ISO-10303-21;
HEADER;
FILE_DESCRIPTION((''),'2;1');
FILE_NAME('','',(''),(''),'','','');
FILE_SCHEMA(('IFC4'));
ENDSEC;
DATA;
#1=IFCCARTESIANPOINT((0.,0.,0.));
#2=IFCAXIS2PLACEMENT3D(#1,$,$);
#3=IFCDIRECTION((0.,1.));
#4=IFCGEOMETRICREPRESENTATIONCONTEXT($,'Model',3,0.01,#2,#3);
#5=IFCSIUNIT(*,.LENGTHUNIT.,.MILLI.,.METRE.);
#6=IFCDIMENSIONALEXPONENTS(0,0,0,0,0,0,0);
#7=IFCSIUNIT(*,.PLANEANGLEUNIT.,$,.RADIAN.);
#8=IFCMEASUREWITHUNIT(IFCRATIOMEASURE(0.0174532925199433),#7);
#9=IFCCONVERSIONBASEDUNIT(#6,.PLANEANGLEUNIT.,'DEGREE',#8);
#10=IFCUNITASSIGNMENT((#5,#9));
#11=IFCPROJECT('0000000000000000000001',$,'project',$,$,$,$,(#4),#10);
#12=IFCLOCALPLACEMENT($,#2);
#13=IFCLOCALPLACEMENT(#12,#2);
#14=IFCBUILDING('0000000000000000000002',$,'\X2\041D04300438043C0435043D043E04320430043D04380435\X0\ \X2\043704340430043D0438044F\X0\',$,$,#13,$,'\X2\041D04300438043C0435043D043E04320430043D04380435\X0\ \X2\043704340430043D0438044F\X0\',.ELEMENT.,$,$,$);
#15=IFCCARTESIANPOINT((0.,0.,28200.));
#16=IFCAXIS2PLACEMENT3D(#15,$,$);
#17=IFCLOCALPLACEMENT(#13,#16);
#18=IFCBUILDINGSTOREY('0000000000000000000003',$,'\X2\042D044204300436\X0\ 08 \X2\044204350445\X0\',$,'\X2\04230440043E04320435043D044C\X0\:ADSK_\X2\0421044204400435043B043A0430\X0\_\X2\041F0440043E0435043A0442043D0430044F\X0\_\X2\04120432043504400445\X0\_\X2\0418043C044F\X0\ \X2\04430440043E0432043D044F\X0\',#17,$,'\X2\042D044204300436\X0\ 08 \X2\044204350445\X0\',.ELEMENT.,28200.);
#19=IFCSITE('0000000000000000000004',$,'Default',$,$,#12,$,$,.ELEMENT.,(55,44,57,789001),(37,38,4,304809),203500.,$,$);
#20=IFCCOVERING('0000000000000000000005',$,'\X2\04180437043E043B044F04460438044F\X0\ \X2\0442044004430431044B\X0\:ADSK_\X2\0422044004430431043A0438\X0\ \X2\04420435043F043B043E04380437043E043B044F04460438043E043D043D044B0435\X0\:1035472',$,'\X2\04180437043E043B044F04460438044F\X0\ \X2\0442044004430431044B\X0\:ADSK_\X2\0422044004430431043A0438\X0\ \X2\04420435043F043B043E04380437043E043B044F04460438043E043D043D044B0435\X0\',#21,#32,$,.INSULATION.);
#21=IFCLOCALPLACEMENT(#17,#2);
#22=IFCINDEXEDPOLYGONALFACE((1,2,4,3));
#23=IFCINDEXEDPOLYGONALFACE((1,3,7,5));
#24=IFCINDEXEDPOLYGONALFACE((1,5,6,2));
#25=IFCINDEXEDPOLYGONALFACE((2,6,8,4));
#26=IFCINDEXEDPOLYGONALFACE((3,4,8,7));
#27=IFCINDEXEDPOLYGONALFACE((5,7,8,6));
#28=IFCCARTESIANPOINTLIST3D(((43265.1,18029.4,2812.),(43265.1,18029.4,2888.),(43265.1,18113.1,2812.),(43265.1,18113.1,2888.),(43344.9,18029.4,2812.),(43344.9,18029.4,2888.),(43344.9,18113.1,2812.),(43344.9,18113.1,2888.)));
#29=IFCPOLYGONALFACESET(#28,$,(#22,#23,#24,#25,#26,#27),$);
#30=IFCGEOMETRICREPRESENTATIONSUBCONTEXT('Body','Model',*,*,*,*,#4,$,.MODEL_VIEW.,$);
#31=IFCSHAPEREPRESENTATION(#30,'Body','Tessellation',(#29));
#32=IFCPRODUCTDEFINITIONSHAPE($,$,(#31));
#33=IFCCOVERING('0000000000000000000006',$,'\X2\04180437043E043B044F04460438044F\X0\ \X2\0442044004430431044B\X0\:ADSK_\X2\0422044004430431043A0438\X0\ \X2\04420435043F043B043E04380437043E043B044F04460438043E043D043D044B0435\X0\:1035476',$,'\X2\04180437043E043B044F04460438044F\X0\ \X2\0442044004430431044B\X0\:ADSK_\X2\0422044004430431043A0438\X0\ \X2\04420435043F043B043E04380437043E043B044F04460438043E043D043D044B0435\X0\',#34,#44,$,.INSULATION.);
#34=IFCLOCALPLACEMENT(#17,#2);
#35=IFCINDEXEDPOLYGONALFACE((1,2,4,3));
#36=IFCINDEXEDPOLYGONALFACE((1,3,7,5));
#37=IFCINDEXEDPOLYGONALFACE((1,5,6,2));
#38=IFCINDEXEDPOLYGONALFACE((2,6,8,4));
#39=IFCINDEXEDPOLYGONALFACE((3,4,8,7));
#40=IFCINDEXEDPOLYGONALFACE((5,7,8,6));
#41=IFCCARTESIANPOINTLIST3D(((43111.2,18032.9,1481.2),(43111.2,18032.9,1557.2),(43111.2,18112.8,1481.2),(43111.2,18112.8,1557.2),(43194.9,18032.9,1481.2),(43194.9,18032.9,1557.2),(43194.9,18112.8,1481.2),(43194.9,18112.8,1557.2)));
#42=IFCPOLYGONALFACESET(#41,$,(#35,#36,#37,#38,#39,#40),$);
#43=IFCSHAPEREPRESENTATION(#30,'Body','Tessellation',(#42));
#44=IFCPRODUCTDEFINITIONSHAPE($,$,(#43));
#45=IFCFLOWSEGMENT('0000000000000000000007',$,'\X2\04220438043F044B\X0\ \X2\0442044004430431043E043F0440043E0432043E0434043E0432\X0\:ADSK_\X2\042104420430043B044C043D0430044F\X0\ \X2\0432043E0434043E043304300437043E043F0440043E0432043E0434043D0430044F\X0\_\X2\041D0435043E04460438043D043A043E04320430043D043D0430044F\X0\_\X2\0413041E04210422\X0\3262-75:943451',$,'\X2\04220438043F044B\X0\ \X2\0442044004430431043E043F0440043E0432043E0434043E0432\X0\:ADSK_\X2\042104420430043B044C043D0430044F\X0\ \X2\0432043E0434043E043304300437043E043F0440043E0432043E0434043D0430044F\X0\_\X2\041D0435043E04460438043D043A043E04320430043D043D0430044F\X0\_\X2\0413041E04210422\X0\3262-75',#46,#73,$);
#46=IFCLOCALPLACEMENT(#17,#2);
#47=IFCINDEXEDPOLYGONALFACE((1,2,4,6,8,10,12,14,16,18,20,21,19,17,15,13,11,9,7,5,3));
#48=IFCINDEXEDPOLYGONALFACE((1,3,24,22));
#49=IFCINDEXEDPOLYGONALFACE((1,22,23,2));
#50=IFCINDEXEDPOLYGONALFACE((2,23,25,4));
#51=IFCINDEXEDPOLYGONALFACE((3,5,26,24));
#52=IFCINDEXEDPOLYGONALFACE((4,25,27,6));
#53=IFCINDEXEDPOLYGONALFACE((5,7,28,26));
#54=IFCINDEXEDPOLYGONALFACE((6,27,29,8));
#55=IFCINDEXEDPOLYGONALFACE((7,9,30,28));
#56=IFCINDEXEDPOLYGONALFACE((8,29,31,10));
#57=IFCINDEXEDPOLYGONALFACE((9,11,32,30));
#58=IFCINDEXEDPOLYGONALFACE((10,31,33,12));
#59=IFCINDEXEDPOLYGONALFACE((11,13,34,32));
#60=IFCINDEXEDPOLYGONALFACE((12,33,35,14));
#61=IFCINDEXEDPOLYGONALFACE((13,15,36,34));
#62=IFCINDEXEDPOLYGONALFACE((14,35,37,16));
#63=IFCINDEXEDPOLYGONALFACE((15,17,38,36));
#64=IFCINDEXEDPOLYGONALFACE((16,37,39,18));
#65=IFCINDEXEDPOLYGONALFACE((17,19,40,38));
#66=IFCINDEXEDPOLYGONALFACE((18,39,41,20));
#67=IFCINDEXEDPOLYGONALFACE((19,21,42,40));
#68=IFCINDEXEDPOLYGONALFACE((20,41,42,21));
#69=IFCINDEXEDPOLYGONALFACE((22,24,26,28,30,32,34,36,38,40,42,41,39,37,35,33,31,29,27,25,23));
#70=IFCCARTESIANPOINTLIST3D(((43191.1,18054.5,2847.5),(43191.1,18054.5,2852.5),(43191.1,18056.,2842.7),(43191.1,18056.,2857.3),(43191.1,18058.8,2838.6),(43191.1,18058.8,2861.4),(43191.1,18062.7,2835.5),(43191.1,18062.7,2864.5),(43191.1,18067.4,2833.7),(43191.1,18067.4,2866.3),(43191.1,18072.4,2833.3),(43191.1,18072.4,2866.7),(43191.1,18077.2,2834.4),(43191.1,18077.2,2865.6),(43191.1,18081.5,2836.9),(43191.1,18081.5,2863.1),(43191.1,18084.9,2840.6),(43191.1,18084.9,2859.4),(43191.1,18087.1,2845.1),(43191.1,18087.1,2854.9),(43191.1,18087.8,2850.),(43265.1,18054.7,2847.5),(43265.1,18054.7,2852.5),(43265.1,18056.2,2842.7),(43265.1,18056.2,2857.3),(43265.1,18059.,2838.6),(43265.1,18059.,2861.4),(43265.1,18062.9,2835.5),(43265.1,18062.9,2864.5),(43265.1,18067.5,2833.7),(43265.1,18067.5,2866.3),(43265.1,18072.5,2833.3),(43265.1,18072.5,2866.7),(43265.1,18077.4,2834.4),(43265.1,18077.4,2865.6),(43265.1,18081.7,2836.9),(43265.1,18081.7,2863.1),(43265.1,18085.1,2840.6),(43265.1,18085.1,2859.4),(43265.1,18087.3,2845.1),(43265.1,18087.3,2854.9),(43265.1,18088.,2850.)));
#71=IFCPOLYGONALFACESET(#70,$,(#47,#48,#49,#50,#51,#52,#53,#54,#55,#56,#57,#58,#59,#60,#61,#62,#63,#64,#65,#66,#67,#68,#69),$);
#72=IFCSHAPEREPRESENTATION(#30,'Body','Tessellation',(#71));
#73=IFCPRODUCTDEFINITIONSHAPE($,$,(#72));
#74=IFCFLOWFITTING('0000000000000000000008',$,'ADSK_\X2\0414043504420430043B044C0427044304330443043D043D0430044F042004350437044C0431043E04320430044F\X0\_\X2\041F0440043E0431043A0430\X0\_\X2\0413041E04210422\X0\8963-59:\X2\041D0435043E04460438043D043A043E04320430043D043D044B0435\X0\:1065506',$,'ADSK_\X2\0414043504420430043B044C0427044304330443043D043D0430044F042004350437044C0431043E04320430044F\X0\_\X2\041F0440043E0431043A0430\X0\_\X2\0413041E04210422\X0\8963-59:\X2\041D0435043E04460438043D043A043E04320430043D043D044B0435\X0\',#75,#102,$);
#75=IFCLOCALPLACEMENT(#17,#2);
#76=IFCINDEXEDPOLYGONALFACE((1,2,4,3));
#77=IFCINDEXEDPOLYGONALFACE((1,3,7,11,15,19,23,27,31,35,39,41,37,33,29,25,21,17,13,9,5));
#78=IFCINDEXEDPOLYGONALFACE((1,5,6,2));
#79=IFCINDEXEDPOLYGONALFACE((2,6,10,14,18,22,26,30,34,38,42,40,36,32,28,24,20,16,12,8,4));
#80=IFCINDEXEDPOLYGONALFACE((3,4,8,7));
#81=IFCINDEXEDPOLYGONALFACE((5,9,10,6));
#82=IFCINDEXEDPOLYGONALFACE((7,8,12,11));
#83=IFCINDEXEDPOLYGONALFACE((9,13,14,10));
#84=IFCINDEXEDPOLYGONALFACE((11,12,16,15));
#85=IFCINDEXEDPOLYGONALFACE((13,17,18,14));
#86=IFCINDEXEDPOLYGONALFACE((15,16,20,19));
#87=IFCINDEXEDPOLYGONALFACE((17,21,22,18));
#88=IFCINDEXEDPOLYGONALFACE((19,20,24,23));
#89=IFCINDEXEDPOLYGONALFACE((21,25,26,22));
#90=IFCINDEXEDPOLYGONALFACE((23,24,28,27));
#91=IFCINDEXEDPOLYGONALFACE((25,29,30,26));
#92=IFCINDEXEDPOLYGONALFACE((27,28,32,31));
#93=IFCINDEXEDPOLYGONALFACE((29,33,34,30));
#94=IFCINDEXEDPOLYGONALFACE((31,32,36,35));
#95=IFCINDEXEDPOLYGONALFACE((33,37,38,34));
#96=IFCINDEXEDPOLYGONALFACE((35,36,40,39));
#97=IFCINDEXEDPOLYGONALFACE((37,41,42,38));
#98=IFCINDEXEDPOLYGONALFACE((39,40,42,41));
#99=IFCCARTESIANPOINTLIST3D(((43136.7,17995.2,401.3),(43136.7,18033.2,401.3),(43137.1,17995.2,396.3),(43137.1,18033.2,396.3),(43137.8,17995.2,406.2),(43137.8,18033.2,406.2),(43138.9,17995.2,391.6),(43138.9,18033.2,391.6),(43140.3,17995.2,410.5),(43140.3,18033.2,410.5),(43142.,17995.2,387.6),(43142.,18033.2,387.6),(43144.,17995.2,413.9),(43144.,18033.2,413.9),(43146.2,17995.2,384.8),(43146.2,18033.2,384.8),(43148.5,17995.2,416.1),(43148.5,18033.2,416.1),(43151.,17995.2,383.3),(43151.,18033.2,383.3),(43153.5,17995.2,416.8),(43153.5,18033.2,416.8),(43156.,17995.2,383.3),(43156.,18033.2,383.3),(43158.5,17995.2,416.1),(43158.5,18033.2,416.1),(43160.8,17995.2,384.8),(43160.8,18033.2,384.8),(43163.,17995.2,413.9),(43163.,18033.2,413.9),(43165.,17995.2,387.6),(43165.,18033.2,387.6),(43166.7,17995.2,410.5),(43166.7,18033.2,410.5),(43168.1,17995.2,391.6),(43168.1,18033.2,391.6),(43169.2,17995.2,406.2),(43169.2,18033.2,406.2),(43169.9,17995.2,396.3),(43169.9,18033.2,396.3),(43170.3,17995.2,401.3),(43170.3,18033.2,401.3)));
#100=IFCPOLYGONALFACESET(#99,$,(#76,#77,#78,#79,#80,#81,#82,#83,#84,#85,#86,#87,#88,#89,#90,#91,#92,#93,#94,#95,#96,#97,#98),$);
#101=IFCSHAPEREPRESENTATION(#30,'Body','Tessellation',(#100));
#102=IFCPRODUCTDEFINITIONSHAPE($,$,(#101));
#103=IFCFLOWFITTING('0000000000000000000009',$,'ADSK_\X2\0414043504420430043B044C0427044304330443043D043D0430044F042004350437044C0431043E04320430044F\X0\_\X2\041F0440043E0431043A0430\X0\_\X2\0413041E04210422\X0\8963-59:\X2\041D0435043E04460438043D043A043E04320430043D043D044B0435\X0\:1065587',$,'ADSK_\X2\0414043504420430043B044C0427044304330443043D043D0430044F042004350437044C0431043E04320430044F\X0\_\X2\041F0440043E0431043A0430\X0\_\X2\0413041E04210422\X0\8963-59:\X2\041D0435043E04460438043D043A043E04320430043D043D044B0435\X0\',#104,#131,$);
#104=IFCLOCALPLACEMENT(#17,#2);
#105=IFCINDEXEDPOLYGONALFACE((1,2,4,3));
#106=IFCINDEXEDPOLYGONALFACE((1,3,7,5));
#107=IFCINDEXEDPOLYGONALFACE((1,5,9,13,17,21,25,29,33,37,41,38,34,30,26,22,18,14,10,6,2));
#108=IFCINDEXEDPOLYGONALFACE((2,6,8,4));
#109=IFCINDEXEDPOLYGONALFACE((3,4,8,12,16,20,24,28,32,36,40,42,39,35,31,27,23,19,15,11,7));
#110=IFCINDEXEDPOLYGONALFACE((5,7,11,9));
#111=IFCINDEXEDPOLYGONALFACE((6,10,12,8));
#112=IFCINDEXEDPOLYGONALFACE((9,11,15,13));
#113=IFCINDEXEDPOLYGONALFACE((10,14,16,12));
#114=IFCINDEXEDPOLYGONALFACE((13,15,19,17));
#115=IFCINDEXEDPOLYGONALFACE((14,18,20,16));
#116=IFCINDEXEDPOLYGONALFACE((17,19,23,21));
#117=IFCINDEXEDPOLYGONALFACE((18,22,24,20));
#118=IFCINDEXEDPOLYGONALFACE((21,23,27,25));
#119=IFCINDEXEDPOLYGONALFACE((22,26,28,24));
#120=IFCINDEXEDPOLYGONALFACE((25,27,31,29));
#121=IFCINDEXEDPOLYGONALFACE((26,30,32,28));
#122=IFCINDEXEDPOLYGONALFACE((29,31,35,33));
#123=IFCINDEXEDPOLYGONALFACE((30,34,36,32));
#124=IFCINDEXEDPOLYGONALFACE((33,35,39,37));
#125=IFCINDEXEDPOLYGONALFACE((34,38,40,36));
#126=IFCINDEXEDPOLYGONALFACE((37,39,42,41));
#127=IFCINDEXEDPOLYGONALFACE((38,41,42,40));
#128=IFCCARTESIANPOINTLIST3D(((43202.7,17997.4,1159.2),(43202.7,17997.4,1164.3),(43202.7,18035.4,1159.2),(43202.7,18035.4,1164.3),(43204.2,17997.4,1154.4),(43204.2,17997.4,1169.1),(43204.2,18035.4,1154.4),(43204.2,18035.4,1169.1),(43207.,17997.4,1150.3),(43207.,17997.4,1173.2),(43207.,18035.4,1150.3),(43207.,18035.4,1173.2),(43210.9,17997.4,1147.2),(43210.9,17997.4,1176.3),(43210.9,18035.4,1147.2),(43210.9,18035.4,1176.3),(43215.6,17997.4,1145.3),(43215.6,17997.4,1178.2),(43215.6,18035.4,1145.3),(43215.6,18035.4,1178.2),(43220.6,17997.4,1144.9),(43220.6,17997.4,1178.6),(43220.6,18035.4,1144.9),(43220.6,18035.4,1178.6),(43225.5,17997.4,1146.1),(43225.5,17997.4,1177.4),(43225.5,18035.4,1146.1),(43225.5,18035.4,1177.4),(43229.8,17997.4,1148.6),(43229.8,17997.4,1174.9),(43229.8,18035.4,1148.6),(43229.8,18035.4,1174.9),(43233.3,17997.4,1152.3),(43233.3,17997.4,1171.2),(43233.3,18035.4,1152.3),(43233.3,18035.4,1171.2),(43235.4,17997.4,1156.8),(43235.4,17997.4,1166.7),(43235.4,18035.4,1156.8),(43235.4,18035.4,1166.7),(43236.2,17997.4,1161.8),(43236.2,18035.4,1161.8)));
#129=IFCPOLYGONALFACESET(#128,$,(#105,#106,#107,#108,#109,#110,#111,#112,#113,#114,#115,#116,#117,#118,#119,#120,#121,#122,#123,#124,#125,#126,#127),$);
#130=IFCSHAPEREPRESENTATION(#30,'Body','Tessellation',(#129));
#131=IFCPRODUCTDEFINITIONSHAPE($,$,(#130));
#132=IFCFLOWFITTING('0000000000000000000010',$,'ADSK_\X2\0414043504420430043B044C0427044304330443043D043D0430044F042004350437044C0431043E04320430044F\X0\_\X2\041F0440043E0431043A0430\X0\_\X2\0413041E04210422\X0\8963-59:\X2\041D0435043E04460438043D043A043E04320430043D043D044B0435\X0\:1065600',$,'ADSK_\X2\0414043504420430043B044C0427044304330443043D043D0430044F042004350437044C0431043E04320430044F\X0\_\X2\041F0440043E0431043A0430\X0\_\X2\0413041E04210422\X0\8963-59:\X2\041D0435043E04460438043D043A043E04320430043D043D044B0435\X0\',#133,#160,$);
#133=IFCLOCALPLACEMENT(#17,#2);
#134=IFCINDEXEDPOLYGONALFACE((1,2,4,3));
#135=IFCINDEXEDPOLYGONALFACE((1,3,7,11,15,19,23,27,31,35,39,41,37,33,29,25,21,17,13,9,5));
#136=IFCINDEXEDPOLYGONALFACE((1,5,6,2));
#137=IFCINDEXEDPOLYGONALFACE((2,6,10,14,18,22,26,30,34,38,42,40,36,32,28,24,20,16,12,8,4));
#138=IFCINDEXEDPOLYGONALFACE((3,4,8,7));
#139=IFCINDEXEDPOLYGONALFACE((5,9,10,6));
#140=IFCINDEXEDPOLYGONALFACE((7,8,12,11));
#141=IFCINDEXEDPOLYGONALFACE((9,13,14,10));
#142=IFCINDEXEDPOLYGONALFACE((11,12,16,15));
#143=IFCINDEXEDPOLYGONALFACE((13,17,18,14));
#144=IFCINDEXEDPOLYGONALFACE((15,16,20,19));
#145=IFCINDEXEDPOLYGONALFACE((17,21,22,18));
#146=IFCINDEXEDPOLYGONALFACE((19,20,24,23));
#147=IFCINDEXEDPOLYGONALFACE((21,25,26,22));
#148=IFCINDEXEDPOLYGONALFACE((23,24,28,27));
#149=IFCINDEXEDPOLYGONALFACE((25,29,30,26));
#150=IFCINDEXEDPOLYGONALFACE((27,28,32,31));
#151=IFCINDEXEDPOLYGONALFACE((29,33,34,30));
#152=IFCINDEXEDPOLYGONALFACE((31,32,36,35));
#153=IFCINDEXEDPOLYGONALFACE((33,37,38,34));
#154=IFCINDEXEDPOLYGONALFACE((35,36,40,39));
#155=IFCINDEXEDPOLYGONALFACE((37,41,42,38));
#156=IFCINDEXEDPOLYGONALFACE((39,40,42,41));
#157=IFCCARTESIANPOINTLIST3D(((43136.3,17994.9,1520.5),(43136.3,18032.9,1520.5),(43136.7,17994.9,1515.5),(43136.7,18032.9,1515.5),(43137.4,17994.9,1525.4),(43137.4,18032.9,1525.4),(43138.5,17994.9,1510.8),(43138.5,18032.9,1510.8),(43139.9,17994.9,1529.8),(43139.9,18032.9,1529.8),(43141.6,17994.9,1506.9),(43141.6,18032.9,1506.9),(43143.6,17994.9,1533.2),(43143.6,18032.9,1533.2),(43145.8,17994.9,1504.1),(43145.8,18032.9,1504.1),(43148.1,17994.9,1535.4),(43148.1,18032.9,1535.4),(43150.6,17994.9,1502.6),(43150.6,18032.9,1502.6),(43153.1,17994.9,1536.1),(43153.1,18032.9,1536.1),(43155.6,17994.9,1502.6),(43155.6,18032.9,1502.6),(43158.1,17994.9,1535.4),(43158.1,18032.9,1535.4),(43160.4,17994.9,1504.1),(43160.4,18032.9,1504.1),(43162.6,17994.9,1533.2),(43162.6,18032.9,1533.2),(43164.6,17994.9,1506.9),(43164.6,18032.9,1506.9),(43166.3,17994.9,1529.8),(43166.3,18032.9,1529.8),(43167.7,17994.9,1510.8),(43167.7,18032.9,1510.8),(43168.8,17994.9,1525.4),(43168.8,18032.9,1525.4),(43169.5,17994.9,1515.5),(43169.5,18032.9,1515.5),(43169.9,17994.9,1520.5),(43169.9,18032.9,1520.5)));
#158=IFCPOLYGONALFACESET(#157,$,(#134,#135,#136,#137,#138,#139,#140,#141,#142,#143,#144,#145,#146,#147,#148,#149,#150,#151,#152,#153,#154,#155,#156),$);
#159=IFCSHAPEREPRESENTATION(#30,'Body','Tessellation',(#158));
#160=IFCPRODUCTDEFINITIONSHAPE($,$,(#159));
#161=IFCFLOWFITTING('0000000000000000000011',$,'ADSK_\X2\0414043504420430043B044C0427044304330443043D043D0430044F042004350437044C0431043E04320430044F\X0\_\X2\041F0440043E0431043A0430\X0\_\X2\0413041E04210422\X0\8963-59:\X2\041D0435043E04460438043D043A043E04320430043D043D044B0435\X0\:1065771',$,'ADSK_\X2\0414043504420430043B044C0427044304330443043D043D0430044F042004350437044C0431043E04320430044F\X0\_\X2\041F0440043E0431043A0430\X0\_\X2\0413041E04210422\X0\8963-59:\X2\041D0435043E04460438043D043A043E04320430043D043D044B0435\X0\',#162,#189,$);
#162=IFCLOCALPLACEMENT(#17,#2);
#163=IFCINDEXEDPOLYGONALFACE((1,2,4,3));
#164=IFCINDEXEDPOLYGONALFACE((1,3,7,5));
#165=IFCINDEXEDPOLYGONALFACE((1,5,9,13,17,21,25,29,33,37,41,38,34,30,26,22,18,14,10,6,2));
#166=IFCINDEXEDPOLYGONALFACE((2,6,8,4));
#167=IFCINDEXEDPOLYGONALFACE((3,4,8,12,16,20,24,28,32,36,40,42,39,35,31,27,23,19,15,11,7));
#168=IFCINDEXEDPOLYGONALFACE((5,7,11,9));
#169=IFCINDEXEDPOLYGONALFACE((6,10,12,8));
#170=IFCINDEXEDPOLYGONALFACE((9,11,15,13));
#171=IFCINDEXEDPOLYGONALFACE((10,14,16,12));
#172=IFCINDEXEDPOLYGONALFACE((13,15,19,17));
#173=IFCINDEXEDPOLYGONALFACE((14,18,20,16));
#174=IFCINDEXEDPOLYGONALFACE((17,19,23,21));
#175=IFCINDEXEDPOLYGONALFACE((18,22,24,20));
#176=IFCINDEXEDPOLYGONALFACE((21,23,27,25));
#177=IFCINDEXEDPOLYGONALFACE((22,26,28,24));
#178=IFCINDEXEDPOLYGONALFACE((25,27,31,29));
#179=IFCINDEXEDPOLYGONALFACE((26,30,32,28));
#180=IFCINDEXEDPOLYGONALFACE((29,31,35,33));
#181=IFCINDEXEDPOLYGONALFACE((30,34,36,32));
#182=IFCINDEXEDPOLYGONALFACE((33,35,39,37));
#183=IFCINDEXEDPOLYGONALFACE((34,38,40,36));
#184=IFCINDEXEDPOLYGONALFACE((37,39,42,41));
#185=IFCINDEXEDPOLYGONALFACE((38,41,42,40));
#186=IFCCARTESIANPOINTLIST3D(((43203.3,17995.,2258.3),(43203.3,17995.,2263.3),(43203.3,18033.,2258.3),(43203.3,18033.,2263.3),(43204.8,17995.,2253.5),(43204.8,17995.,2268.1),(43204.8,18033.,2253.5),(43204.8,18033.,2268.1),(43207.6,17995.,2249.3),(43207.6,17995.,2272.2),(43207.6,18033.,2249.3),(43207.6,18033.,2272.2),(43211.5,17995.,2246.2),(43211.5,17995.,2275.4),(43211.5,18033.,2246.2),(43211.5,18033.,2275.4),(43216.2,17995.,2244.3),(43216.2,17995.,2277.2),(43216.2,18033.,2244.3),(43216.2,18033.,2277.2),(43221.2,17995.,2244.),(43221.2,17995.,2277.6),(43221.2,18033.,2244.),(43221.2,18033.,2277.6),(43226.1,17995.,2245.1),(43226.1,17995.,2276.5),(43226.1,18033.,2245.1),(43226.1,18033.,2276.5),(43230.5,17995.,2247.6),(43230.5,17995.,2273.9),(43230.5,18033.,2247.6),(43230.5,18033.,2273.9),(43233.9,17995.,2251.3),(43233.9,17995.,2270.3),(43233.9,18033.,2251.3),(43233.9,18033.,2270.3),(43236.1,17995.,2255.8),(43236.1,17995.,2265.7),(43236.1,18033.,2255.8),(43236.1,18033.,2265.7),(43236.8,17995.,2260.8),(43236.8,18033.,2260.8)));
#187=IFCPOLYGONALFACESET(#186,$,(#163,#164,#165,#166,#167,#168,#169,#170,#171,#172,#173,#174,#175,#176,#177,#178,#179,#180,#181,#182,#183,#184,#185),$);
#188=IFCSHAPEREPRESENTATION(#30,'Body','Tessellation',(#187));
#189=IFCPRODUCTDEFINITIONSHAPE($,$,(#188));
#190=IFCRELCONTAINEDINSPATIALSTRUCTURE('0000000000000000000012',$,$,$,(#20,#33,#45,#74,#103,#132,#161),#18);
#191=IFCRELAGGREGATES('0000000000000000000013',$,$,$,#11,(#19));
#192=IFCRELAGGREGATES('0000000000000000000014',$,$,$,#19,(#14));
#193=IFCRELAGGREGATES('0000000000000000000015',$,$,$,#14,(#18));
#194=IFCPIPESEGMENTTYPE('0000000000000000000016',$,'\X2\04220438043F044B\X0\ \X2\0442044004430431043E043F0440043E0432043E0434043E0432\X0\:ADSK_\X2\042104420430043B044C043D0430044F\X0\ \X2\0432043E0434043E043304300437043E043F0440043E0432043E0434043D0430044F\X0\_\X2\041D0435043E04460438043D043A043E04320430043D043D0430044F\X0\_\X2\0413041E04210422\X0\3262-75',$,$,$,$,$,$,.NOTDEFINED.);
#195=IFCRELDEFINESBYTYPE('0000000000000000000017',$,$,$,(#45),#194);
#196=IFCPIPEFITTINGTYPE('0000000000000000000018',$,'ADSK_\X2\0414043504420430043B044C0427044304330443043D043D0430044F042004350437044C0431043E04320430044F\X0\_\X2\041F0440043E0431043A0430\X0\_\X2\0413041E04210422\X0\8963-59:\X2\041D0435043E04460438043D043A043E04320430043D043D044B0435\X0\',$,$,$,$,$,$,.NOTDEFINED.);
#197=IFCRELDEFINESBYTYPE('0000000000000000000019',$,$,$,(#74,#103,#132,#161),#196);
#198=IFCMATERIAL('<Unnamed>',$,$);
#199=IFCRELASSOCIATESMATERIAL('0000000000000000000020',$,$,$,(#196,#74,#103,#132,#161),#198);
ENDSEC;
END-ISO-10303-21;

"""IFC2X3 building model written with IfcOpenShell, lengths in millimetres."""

from ifc_helpers import new_model, entity, si_unit, converted_unit, direction, frame, origin, origin_2d_with_axis, place, context, subcontext, project, spatial, rectangle, circle, extrude, source, transform, mapped, material, type_object, type_shapes, element, save


model = new_model("IFC2X3")

# Units and contexts
model_context = context("Model", 3, precision=0.01, world=origin(), true_north=direction((0.0, 1.0)))
body_context = subcontext(model_context, "Body", "Model", "MODEL_VIEW")
ifc_project = project(units=[si_unit("LENGTHUNIT", "METRE", prefix="MILLI"), converted_unit("PLANEANGLEUNIT", "DEGREE", entity("IfcRatioMeasure", 0.0174532925199433), si_unit("PLANEANGLEUNIT", "RADIAN"), dimensions=[0, 0, 0, 0, 0, 0, 0])], contexts=[model_context])

# Site, building, storey
site_placement = place(None, origin())
site = spatial("IfcSite", under=ifc_project, at=site_placement, Name="Default", CompositionType="ELEMENT", RefLatitude=(55, 44, 57, 789001), RefLongitude=(37, 38, 4, 304809), RefElevation=203500.0)
building_placement = place(site_placement, origin())
building = spatial("IfcBuilding", under=site, at=building_placement, Name="Наименование здания", LongName="Наименование здания", CompositionType="ELEMENT")
storey_placement = place(building_placement, frame((0.0, 0.0, 28200.0)))
storey = spatial("IfcBuildingStorey", under=building, at=storey_placement, Name="Этаж 08 тех", ObjectType="Уровень:ADSK_Стрелка_Проектная_Вверх_Имя уровня", LongName="Этаж 08 тех", CompositionType="ELEMENT", Elevation=28200.0)

# Coverings
covering_1_placement = place(storey_placement, frame((43265.1, 18029.4, 2812.0)))
element("IfcCovering", 1, at=covering_1_placement, inside=storey, Name="Изоляция трубы:ADSK_Трубки теплоизоляционные:1035472", ObjectType="Изоляция трубы:ADSK_Трубки теплоизоляционные", PredefinedType="INSULATION", context=body_context, shape_type="SweptSolid", body=[
    extrude(rectangle(XDim=79.9, YDim=83.7, at=origin_2d_with_axis()), frame((39.9, 41.9, 0.0)), (0.0, 0.0, 1.0), 76.0),
])
covering_2_placement = place(storey_placement, frame((43111.2, 18032.9, 1481.2)))
element("IfcCovering", 2, at=covering_2_placement, inside=storey, Name="Изоляция трубы:ADSK_Трубки теплоизоляционные:1035476", ObjectType="Изоляция трубы:ADSK_Трубки теплоизоляционные", PredefinedType="INSULATION", context=body_context, shape_type="SweptSolid", body=[
    extrude(rectangle(XDim=83.7, YDim=79.9, at=origin_2d_with_axis()), frame((41.9, 39.9, 0.0)), (0.0, 0.0, 1.0), 76.0),
])

# Flow segment
pipe_segment_type = type_object("IfcPipeSegmentType", Name="Типы трубопроводов:ADSK_Стальная водогазопроводная_Неоцинкованная_ГОСТ3262-75", PredefinedType="NOTDEFINED")
flow_segment_1_placement = place(storey_placement, frame((43191.1, 18052.8, 2831.7)))
element("IfcFlowSegment", 3, at=flow_segment_1_placement, inside=storey, type_object=pipe_segment_type, Name="Типы трубопроводов:ADSK_Стальная водогазопроводная_Неоцинкованная_ГОСТ3262-75:943451", ObjectType="Типы трубопроводов:ADSK_Стальная водогазопроводная_Неоцинкованная_ГОСТ3262-75", context=body_context, shape_type="SweptSolid", body=[
    extrude(circle(Radius=16.8, at=origin_2d_with_axis()), frame((0.0, 18.4, 18.4), z_axis=(0.999998, 0.001963, 0.0), x_axis=(-0.001963, 0.999998, 0.0)), (0.0, 0.0, 1.0), 74.0),
])

# Flow fittings
ifc_material = material(Name="<Unnamed>")
pipe_fitting_type_1 = type_object("IfcPipeFittingType", Name="ADSK_ДетальЧугуннаяРезьбовая_Пробка_ГОСТ8963-59:Неоцинкованные", PredefinedType="NOTDEFINED", material=ifc_material)
shared_shape_1 = source(origin(), body_context, "Body", "SweptSolid", [
    extrude(circle(Radius=16.9, at=origin_2d_with_axis()), frame((0.0, 0.0, 0.0), z_axis=(1.0, 0.0, 0.0), x_axis=(0.0, 1.0, 0.0)), (0.0, 0.0, 1.0), 38.0),
])
type_shapes(pipe_fitting_type_1, [shared_shape_1])
for number, where, z_axis, x_axis, name in (
    (4, (43153.5, 18033.2, 400.0), (-1.0, 0.0, 0.0), (0.0, -1.0, 0.0), "ADSK_ДетальЧугуннаяРезьбовая_Пробка_ГОСТ8963-59:Неоцинкованные:1065506"),
    (5, (43219.3, 18035.4, 1161.8), (0.0, 0.0, 1.0), (0.0, -1.0, 0.0), "ADSK_ДетальЧугуннаяРезьбовая_Пробка_ГОСТ8963-59:Неоцинкованные:1065587"),
    (6, (43153.1, 18032.9, 1519.2), (-1.0, 0.0, 0.0), (0.0, -1.0, 0.0), "ADSK_ДетальЧугуннаяРезьбовая_Пробка_ГОСТ8963-59:Неоцинкованные:1065600"),
    (7, (43220.0, 18033.0, 2260.8), (0.0, 0.0, 1.0), (0.0, -1.0, 0.0), "ADSK_ДетальЧугуннаяРезьбовая_Пробка_ГОСТ8963-59:Неоцинкованные:1065771"),
):
    element("IfcFlowFitting", number, at=place(storey_placement, frame(where, z_axis=z_axis, x_axis=x_axis)), inside=storey, type_object=pipe_fitting_type_1, material=ifc_material, Name=name, ObjectType="ADSK_ДетальЧугуннаяРезьбовая_Пробка_ГОСТ8963-59:Неоцинкованные", context=body_context, shape_type="MappedRepresentation", body=[
        mapped(shared_shape_1, transform((0.0, 0.0, 0.0), scale=1.0)),
    ])

save(model, "model.ifc")
